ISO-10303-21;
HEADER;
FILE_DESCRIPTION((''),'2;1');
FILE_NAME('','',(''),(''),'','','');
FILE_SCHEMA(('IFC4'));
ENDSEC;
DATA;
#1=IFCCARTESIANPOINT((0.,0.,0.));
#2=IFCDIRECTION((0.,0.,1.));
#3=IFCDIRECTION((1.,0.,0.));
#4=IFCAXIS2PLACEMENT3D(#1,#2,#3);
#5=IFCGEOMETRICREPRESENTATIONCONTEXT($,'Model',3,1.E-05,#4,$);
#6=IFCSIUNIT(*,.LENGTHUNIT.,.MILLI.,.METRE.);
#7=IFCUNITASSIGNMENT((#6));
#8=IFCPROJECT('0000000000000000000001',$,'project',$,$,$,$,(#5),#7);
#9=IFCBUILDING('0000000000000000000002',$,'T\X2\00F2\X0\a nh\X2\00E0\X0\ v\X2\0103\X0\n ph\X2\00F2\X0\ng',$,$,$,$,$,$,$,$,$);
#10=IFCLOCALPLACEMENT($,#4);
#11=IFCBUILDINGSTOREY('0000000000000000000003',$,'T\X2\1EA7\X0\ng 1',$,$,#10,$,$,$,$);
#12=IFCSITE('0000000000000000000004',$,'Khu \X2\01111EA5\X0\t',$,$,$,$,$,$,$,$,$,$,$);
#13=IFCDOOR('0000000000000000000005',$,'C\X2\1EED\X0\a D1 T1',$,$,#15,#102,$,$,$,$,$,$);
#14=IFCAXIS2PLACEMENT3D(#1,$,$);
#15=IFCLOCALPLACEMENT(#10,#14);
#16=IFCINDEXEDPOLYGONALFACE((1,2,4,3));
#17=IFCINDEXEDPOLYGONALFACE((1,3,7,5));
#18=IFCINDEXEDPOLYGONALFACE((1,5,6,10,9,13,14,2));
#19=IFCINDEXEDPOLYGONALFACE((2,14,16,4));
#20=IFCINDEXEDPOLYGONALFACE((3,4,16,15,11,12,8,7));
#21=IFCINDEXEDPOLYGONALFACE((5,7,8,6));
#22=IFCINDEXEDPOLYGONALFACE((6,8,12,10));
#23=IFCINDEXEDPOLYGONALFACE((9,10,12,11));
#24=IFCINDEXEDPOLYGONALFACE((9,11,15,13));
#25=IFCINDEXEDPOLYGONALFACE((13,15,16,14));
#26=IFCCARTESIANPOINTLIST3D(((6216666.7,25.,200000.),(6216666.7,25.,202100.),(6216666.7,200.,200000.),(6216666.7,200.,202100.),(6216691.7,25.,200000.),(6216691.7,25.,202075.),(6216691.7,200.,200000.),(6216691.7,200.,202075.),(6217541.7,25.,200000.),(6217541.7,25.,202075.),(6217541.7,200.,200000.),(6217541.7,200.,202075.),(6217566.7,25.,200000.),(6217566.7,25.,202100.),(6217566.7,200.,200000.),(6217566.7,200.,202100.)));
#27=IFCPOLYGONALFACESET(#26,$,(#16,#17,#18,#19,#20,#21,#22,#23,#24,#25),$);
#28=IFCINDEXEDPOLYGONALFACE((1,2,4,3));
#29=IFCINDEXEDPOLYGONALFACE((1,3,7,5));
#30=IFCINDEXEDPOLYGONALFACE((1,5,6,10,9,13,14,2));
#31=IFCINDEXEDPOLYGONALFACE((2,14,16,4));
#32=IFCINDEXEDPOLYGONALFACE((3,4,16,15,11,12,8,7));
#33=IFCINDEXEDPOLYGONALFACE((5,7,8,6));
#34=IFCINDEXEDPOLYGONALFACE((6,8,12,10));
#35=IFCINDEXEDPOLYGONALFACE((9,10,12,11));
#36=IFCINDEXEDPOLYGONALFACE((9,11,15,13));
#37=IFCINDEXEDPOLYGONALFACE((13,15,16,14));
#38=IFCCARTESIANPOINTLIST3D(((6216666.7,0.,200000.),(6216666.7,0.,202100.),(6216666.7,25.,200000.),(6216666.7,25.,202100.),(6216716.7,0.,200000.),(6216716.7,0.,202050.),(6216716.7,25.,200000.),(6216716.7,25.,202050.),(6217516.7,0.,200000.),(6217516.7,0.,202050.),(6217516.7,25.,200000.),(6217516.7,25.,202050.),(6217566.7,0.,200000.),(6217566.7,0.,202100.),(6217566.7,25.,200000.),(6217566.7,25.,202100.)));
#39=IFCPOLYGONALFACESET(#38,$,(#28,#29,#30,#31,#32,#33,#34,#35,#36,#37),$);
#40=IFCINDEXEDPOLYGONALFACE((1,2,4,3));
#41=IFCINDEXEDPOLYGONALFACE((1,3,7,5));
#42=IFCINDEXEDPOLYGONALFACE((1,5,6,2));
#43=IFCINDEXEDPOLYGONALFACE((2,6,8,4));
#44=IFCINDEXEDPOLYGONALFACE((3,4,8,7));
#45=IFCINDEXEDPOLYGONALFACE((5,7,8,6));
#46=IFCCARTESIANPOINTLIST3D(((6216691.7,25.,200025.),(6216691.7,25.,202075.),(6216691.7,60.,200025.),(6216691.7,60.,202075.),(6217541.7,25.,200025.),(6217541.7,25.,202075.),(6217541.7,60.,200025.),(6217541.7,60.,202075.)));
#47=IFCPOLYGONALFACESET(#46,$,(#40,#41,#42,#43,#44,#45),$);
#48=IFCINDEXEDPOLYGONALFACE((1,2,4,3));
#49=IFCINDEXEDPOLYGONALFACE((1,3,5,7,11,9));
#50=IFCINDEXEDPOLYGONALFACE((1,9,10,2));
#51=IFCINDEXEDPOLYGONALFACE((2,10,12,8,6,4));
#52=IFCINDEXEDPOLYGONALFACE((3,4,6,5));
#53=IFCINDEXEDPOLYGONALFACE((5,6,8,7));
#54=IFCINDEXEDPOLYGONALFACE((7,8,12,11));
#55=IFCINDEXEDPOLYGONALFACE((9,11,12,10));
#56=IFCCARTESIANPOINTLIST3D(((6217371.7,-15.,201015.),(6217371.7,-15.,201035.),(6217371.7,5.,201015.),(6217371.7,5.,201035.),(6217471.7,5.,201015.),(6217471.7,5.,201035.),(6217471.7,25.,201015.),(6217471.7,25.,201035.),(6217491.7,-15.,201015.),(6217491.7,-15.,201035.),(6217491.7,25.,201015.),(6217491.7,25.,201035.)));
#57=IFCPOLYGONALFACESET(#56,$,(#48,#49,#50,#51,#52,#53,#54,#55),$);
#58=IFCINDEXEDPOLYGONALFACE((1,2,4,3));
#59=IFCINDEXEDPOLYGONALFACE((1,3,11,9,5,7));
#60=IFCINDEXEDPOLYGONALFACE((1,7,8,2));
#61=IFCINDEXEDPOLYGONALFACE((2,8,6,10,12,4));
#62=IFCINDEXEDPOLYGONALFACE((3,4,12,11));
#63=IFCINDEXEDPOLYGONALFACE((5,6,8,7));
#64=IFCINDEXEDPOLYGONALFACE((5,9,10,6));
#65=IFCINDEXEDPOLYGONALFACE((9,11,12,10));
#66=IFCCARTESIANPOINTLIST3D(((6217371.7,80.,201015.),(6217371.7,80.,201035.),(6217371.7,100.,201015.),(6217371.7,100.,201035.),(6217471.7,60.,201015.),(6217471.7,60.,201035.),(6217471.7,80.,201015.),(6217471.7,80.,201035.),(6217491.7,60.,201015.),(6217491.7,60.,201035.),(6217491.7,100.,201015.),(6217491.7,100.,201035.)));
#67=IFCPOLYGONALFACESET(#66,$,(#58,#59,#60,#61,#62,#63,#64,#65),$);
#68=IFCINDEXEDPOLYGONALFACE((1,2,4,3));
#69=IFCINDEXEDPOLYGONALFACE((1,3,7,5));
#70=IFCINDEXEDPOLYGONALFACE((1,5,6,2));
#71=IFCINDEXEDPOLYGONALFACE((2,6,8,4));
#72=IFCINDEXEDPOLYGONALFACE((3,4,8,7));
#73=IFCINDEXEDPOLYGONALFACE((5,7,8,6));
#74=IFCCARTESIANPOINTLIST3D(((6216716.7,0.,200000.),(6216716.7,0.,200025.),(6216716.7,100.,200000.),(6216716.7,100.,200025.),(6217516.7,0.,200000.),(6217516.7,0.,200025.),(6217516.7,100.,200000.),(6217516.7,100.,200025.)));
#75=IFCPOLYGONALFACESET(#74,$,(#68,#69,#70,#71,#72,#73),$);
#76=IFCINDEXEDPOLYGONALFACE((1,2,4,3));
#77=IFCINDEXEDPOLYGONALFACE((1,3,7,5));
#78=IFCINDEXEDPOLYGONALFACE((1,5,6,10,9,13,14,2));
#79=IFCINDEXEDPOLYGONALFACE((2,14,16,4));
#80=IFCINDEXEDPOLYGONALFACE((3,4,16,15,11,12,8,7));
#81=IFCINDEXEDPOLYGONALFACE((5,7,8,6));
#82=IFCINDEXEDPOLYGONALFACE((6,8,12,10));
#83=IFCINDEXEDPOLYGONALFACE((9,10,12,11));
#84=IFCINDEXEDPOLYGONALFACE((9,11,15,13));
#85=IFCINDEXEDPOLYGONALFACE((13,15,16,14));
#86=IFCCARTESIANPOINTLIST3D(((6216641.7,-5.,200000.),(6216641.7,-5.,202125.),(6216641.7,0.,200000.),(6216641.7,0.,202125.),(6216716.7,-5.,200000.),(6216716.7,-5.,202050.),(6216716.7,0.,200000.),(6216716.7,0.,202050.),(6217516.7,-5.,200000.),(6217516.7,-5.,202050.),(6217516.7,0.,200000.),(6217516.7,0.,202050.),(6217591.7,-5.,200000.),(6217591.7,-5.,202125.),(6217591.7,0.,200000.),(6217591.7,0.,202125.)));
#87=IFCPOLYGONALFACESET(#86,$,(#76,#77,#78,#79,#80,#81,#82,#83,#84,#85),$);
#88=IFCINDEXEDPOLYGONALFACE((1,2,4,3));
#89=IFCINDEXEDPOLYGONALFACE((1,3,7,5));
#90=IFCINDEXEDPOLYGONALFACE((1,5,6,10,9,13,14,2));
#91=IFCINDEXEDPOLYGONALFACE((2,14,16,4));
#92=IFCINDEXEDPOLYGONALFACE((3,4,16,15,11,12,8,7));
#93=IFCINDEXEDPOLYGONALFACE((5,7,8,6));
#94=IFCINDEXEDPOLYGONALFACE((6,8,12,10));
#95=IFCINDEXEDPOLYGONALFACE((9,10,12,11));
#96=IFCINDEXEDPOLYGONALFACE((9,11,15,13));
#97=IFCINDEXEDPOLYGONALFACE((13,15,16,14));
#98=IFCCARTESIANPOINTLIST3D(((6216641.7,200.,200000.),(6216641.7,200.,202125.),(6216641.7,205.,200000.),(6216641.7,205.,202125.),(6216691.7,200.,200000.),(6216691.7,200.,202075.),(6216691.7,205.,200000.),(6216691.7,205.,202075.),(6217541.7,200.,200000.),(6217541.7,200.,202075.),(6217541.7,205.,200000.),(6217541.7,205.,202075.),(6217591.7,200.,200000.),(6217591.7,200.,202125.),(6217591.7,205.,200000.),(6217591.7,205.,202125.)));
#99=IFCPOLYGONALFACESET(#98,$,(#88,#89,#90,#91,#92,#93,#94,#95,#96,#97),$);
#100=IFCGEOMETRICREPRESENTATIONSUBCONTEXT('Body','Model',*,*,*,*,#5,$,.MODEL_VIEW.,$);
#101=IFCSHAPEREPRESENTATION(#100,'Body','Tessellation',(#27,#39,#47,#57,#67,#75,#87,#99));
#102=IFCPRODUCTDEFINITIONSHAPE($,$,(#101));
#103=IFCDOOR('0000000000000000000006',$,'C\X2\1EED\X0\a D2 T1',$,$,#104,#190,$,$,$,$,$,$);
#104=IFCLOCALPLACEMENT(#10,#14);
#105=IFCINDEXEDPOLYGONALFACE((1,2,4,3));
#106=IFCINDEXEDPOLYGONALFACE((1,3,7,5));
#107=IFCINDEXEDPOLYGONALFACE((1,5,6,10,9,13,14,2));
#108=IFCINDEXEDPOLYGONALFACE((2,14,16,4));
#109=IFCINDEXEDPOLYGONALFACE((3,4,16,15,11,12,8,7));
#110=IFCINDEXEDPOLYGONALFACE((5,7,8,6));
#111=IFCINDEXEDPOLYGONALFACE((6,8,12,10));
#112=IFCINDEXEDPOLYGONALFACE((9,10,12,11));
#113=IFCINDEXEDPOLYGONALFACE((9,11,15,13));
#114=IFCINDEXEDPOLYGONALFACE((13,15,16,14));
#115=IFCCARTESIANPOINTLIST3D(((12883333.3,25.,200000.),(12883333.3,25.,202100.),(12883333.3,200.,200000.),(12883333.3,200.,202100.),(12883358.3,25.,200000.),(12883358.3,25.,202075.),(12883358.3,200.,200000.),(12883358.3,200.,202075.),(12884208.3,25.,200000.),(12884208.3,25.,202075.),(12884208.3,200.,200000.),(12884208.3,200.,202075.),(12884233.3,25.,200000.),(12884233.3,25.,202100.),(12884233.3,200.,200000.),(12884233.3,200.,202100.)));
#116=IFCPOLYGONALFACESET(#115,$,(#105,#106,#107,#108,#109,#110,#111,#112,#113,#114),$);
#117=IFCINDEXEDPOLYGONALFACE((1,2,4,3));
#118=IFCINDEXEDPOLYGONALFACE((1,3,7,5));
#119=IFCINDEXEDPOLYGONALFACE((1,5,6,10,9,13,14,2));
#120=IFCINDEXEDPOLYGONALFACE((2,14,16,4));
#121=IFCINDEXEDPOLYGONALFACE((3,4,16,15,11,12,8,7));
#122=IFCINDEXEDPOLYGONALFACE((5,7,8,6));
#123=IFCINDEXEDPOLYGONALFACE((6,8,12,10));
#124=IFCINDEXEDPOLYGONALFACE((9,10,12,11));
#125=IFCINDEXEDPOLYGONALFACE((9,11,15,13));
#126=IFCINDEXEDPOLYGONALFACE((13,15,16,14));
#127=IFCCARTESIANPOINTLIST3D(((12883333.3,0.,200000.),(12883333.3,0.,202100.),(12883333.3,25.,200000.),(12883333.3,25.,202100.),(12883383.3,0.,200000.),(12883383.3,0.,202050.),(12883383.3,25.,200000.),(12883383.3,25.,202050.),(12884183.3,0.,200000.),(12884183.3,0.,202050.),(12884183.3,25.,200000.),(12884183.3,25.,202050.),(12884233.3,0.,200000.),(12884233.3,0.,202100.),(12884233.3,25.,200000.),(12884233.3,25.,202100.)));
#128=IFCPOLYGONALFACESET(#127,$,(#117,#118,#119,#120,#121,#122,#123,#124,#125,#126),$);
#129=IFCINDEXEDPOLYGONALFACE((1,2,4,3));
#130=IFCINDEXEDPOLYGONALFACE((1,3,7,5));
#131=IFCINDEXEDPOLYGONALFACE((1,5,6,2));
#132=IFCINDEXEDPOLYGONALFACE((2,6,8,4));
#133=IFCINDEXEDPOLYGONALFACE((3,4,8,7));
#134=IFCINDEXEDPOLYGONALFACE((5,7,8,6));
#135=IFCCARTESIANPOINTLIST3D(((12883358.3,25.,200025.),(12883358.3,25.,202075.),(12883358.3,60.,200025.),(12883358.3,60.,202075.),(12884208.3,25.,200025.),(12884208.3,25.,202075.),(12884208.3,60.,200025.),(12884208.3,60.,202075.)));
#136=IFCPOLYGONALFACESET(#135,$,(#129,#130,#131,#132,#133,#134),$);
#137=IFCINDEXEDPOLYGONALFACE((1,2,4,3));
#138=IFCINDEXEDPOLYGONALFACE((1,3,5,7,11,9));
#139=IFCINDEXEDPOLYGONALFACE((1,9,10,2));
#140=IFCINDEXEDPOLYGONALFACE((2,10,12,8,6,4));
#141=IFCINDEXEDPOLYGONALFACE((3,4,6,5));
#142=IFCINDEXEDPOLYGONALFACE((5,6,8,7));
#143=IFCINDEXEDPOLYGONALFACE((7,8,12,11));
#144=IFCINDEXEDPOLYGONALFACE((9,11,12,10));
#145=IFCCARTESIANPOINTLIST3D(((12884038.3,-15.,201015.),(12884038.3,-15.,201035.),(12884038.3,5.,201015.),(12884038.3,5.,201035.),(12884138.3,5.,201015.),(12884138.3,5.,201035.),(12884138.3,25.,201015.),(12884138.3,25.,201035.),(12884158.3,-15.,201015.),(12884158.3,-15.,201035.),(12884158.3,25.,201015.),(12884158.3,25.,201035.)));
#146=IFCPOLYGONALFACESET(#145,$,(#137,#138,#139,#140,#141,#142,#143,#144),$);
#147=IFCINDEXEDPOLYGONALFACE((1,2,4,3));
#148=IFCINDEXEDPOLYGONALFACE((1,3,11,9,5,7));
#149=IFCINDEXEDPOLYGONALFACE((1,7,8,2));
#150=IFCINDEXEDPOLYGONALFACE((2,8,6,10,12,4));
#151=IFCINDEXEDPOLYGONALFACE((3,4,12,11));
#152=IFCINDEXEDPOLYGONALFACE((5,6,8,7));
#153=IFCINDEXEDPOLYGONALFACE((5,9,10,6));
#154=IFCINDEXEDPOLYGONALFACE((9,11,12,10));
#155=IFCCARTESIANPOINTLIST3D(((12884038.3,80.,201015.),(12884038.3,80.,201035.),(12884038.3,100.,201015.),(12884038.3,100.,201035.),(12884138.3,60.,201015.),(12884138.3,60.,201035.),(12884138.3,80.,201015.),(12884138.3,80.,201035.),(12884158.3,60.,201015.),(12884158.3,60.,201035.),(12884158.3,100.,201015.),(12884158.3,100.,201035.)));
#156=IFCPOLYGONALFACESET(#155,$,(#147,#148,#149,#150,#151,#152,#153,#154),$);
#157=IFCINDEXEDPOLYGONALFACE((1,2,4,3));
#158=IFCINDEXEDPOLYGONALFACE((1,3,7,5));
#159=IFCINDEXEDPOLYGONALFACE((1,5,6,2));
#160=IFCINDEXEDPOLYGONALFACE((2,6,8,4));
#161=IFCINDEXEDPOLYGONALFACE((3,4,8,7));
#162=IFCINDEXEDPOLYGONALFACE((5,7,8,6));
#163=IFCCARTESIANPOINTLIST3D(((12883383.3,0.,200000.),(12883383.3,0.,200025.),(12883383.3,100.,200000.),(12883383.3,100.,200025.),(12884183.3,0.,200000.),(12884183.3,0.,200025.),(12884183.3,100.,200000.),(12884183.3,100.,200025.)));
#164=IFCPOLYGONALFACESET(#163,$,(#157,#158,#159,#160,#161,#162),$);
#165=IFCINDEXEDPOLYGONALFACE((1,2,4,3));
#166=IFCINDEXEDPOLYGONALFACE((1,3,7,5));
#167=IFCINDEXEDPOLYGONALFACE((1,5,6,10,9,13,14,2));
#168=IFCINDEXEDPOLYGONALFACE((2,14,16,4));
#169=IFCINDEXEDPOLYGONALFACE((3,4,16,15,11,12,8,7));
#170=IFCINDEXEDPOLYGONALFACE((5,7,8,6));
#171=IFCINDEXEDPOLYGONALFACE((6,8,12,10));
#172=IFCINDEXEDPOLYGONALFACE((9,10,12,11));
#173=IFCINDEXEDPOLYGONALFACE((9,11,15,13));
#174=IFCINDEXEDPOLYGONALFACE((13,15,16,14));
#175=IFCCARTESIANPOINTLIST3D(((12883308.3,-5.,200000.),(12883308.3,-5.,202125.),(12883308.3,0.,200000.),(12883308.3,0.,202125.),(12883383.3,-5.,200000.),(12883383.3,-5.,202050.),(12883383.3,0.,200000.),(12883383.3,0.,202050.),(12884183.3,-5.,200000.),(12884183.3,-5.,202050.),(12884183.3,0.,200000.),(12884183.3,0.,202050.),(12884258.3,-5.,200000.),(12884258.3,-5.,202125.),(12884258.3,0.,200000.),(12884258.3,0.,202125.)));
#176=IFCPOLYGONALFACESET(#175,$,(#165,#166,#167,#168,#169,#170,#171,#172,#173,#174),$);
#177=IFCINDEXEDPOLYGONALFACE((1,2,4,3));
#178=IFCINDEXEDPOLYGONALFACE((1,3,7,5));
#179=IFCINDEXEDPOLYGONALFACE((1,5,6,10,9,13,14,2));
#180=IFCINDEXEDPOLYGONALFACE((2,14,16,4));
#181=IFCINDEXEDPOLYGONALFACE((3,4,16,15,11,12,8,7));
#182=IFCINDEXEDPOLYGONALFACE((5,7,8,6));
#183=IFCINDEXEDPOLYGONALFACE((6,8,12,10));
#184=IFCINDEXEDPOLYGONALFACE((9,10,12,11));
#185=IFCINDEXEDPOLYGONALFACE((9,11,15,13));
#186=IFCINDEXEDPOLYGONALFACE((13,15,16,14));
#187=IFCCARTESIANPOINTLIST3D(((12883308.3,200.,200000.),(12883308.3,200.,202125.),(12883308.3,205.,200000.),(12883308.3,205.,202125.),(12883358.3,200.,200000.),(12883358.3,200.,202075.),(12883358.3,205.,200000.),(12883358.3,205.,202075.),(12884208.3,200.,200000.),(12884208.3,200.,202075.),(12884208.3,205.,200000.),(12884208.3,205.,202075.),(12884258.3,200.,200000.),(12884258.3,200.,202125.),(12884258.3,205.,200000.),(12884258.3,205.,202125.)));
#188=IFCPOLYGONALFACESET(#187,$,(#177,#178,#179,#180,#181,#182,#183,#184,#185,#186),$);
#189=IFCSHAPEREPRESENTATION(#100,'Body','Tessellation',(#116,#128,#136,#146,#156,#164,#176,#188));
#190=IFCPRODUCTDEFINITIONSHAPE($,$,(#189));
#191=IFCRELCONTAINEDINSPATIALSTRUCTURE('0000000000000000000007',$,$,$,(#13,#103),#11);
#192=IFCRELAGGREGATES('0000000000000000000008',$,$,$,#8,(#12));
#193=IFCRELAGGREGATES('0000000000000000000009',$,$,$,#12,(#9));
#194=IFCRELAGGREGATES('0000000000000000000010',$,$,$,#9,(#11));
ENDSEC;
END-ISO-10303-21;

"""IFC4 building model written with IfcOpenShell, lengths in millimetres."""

from ifc_helpers import new_model, si_unit, frame, origin_with_axes, place, context, subcontext, project, spatial, line, indexed_curve, outline, extrude, element, save


model = new_model("IFC4")

# Units and contexts
model_context = context("Model", 3, precision=1e-05, world=origin_with_axes())
body_context = subcontext(model_context, "Body", "Model", "MODEL_VIEW")
ifc_project = project(units=[si_unit("LENGTHUNIT", "METRE", prefix="MILLI")], contexts=[model_context])

# Site, building, storey
site = spatial("IfcSite", under=ifc_project, Name="Khu đất")
building = spatial("IfcBuilding", under=site, Name="Tòa nhà văn phòng")
storey_placement = place(None, origin_with_axes())
storey = spatial("IfcBuildingStorey", under=building, at=storey_placement, Name="Tầng 1")

# Doors
door_1_placement = place(storey_placement, frame((6216666.7, 0.0, 200000.0), z_axis=(0.0, 0.0, 1.0), x_axis=(1.0, 0.0, 0.0)))
element("IfcDoor", 1, at=door_1_placement, inside=storey, Name="Cửa D1 T1", context=body_context, shape_type="SolidModel", body=[
    extrude(outline(indexed_curve([(0.0, 0.0), (0.0, 2100.0), (900.0, 2100.0), (900.0, 0.0), (875.0, 0.0), (875.0, 2075.0), (25.0, 2075.0), (25.0, 0.0)], segments=[line(1, 2, 3, 4, 5, 6, 7, 8, 1)])), frame((0.0, 25.0, 0.0), z_axis=(0.0, -1.0, 0.0), x_axis=(1.0, 0.0, 0.0)), (0.0, 0.0, -1.0), 175.0),
    extrude(outline(indexed_curve([(0.0, 0.0), (0.0, 2100.0), (900.0, 2100.0), (900.0, 0.0), (850.0, 0.0), (850.0, 2050.0), (50.0, 2050.0), (50.0, 0.0)], segments=[line(1, 2, 3, 4, 5, 6, 7, 8, 1)])), frame((0.0, 0.0, 0.0), z_axis=(0.0, -1.0, 0.0), x_axis=(1.0, 0.0, 0.0)), (0.0, 0.0, -1.0), 25.0),
    extrude(outline(indexed_curve([(0.0, 0.0), (850.0, 0.0), (850.0, 35.0), (0.0, 35.0)], segments=[line(1, 2, 3, 4, 1)])), frame((25.0, 25.0, 25.0), z_axis=(0.0, 0.0, 1.0), x_axis=(1.0, 0.0, 0.0)), (0.0, 0.0, 1.0), 2050.0),
    extrude(outline(indexed_curve([(0.0, 0.0), (0.0, -40.0), (-120.0, -40.0), (-120.0, -20.0), (-20.0, -20.0), (-20.0, 0.0)], segments=[line(1, 2, 3, 4, 5, 6, 1)])), frame((825.0, 25.0, 1015.0), z_axis=(0.0, 0.0, 1.0), x_axis=(1.0, 0.0, 0.0)), (0.0, 0.0, 1.0), 20.0),
    extrude(outline(indexed_curve([(0.0, 0.0), (0.0, 40.0), (-120.0, 40.0), (-120.0, 20.0), (-20.0, 20.0), (-20.0, 0.0)], segments=[line(1, 2, 3, 4, 5, 6, 1)])), frame((825.0, 60.0, 1015.0), z_axis=(0.0, 0.0, 1.0), x_axis=(1.0, 0.0, 0.0)), (0.0, 0.0, 1.0), 20.0),
    extrude(outline(indexed_curve([(0.0, 0.0), (800.0, 0.0), (800.0, 100.0), (0.0, 100.0)], segments=[line(1, 2, 3, 4, 1)])), frame((50.0, 0.0, 0.0), z_axis=(0.0, 0.0, 1.0), x_axis=(1.0, 0.0, 0.0)), (0.0, 0.0, 1.0), 25.0),
    extrude(outline(indexed_curve([(0.0, 0.0), (0.0, 2125.0), (950.0, 2125.0), (950.0, 0.0), (875.0, 0.0), (875.0, 2050.0), (75.0, 2050.0), (75.0, 0.0)], segments=[line(1, 2, 3, 4, 5, 6, 7, 8, 1)])), frame((-25.0, -5.0, 0.0), z_axis=(0.0, -1.0, 0.0), x_axis=(1.0, 0.0, 0.0)), (0.0, 0.0, -1.0), 5.0),
    extrude(outline(indexed_curve([(0.0, 0.0), (0.0, 2125.0), (950.0, 2125.0), (950.0, 0.0), (900.0, 0.0), (900.0, 2075.0), (50.0, 2075.0), (50.0, 0.0)], segments=[line(1, 2, 3, 4, 5, 6, 7, 8, 1)])), frame((-25.0, 200.0, 0.0), z_axis=(0.0, -1.0, 0.0), x_axis=(1.0, 0.0, 0.0)), (0.0, 0.0, -1.0), 5.0),
])
door_2_placement = place(storey_placement, frame((12883333.3, 0.0, 200000.0), z_axis=(0.0, 0.0, 1.0), x_axis=(1.0, 0.0, 0.0)))
element("IfcDoor", 2, at=door_2_placement, inside=storey, Name="Cửa D2 T1", context=body_context, shape_type="SolidModel", body=[
    extrude(outline(indexed_curve([(0.0, 0.0), (0.0, 2100.0), (900.0, 2100.0), (900.0, 0.0), (875.0, 0.0), (875.0, 2075.0), (25.0, 2075.0), (25.0, 0.0)], segments=[line(1, 2, 3, 4, 5, 6, 7, 8, 1)])), frame((0.0, 25.0, 0.0), z_axis=(0.0, -1.0, 0.0), x_axis=(1.0, 0.0, 0.0)), (0.0, 0.0, -1.0), 175.0),
    extrude(outline(indexed_curve([(0.0, 0.0), (0.0, 2100.0), (900.0, 2100.0), (900.0, 0.0), (850.0, 0.0), (850.0, 2050.0), (50.0, 2050.0), (50.0, 0.0)], segments=[line(1, 2, 3, 4, 5, 6, 7, 8, 1)])), frame((0.0, 0.0, 0.0), z_axis=(0.0, -1.0, 0.0), x_axis=(1.0, 0.0, 0.0)), (0.0, 0.0, -1.0), 25.0),
    extrude(outline(indexed_curve([(0.0, 0.0), (850.0, 0.0), (850.0, 35.0), (0.0, 35.0)], segments=[line(1, 2, 3, 4, 1)])), frame((25.0, 25.0, 25.0), z_axis=(0.0, 0.0, 1.0), x_axis=(1.0, 0.0, 0.0)), (0.0, 0.0, 1.0), 2050.0),
    extrude(outline(indexed_curve([(0.0, 0.0), (0.0, -40.0), (-120.0, -40.0), (-120.0, -20.0), (-20.0, -20.0), (-20.0, 0.0)], segments=[line(1, 2, 3, 4, 5, 6, 1)])), frame((825.0, 25.0, 1015.0), z_axis=(0.0, 0.0, 1.0), x_axis=(1.0, 0.0, 0.0)), (0.0, 0.0, 1.0), 20.0),
    extrude(outline(indexed_curve([(0.0, 0.0), (0.0, 40.0), (-120.0, 40.0), (-120.0, 20.0), (-20.0, 20.0), (-20.0, 0.0)], segments=[line(1, 2, 3, 4, 5, 6, 1)])), frame((825.0, 60.0, 1015.0), z_axis=(0.0, 0.0, 1.0), x_axis=(1.0, 0.0, 0.0)), (0.0, 0.0, 1.0), 20.0),
    extrude(outline(indexed_curve([(0.0, 0.0), (800.0, 0.0), (800.0, 100.0), (0.0, 100.0)], segments=[line(1, 2, 3, 4, 1)])), frame((50.0, 0.0, 0.0), z_axis=(0.0, 0.0, 1.0), x_axis=(1.0, 0.0, 0.0)), (0.0, 0.0, 1.0), 25.0),
    extrude(outline(indexed_curve([(0.0, 0.0), (0.0, 2125.0), (950.0, 2125.0), (950.0, 0.0), (875.0, 0.0), (875.0, 2050.0), (75.0, 2050.0), (75.0, 0.0)], segments=[line(1, 2, 3, 4, 5, 6, 7, 8, 1)])), frame((-25.0, -5.0, 0.0), z_axis=(0.0, -1.0, 0.0), x_axis=(1.0, 0.0, 0.0)), (0.0, 0.0, -1.0), 5.0),
    extrude(outline(indexed_curve([(0.0, 0.0), (0.0, 2125.0), (950.0, 2125.0), (950.0, 0.0), (900.0, 0.0), (900.0, 2075.0), (50.0, 2075.0), (50.0, 0.0)], segments=[line(1, 2, 3, 4, 5, 6, 7, 8, 1)])), frame((-25.0, 200.0, 0.0), z_axis=(0.0, -1.0, 0.0), x_axis=(1.0, 0.0, 0.0)), (0.0, 0.0, -1.0), 5.0),
])

save(model, "model.ifc")
